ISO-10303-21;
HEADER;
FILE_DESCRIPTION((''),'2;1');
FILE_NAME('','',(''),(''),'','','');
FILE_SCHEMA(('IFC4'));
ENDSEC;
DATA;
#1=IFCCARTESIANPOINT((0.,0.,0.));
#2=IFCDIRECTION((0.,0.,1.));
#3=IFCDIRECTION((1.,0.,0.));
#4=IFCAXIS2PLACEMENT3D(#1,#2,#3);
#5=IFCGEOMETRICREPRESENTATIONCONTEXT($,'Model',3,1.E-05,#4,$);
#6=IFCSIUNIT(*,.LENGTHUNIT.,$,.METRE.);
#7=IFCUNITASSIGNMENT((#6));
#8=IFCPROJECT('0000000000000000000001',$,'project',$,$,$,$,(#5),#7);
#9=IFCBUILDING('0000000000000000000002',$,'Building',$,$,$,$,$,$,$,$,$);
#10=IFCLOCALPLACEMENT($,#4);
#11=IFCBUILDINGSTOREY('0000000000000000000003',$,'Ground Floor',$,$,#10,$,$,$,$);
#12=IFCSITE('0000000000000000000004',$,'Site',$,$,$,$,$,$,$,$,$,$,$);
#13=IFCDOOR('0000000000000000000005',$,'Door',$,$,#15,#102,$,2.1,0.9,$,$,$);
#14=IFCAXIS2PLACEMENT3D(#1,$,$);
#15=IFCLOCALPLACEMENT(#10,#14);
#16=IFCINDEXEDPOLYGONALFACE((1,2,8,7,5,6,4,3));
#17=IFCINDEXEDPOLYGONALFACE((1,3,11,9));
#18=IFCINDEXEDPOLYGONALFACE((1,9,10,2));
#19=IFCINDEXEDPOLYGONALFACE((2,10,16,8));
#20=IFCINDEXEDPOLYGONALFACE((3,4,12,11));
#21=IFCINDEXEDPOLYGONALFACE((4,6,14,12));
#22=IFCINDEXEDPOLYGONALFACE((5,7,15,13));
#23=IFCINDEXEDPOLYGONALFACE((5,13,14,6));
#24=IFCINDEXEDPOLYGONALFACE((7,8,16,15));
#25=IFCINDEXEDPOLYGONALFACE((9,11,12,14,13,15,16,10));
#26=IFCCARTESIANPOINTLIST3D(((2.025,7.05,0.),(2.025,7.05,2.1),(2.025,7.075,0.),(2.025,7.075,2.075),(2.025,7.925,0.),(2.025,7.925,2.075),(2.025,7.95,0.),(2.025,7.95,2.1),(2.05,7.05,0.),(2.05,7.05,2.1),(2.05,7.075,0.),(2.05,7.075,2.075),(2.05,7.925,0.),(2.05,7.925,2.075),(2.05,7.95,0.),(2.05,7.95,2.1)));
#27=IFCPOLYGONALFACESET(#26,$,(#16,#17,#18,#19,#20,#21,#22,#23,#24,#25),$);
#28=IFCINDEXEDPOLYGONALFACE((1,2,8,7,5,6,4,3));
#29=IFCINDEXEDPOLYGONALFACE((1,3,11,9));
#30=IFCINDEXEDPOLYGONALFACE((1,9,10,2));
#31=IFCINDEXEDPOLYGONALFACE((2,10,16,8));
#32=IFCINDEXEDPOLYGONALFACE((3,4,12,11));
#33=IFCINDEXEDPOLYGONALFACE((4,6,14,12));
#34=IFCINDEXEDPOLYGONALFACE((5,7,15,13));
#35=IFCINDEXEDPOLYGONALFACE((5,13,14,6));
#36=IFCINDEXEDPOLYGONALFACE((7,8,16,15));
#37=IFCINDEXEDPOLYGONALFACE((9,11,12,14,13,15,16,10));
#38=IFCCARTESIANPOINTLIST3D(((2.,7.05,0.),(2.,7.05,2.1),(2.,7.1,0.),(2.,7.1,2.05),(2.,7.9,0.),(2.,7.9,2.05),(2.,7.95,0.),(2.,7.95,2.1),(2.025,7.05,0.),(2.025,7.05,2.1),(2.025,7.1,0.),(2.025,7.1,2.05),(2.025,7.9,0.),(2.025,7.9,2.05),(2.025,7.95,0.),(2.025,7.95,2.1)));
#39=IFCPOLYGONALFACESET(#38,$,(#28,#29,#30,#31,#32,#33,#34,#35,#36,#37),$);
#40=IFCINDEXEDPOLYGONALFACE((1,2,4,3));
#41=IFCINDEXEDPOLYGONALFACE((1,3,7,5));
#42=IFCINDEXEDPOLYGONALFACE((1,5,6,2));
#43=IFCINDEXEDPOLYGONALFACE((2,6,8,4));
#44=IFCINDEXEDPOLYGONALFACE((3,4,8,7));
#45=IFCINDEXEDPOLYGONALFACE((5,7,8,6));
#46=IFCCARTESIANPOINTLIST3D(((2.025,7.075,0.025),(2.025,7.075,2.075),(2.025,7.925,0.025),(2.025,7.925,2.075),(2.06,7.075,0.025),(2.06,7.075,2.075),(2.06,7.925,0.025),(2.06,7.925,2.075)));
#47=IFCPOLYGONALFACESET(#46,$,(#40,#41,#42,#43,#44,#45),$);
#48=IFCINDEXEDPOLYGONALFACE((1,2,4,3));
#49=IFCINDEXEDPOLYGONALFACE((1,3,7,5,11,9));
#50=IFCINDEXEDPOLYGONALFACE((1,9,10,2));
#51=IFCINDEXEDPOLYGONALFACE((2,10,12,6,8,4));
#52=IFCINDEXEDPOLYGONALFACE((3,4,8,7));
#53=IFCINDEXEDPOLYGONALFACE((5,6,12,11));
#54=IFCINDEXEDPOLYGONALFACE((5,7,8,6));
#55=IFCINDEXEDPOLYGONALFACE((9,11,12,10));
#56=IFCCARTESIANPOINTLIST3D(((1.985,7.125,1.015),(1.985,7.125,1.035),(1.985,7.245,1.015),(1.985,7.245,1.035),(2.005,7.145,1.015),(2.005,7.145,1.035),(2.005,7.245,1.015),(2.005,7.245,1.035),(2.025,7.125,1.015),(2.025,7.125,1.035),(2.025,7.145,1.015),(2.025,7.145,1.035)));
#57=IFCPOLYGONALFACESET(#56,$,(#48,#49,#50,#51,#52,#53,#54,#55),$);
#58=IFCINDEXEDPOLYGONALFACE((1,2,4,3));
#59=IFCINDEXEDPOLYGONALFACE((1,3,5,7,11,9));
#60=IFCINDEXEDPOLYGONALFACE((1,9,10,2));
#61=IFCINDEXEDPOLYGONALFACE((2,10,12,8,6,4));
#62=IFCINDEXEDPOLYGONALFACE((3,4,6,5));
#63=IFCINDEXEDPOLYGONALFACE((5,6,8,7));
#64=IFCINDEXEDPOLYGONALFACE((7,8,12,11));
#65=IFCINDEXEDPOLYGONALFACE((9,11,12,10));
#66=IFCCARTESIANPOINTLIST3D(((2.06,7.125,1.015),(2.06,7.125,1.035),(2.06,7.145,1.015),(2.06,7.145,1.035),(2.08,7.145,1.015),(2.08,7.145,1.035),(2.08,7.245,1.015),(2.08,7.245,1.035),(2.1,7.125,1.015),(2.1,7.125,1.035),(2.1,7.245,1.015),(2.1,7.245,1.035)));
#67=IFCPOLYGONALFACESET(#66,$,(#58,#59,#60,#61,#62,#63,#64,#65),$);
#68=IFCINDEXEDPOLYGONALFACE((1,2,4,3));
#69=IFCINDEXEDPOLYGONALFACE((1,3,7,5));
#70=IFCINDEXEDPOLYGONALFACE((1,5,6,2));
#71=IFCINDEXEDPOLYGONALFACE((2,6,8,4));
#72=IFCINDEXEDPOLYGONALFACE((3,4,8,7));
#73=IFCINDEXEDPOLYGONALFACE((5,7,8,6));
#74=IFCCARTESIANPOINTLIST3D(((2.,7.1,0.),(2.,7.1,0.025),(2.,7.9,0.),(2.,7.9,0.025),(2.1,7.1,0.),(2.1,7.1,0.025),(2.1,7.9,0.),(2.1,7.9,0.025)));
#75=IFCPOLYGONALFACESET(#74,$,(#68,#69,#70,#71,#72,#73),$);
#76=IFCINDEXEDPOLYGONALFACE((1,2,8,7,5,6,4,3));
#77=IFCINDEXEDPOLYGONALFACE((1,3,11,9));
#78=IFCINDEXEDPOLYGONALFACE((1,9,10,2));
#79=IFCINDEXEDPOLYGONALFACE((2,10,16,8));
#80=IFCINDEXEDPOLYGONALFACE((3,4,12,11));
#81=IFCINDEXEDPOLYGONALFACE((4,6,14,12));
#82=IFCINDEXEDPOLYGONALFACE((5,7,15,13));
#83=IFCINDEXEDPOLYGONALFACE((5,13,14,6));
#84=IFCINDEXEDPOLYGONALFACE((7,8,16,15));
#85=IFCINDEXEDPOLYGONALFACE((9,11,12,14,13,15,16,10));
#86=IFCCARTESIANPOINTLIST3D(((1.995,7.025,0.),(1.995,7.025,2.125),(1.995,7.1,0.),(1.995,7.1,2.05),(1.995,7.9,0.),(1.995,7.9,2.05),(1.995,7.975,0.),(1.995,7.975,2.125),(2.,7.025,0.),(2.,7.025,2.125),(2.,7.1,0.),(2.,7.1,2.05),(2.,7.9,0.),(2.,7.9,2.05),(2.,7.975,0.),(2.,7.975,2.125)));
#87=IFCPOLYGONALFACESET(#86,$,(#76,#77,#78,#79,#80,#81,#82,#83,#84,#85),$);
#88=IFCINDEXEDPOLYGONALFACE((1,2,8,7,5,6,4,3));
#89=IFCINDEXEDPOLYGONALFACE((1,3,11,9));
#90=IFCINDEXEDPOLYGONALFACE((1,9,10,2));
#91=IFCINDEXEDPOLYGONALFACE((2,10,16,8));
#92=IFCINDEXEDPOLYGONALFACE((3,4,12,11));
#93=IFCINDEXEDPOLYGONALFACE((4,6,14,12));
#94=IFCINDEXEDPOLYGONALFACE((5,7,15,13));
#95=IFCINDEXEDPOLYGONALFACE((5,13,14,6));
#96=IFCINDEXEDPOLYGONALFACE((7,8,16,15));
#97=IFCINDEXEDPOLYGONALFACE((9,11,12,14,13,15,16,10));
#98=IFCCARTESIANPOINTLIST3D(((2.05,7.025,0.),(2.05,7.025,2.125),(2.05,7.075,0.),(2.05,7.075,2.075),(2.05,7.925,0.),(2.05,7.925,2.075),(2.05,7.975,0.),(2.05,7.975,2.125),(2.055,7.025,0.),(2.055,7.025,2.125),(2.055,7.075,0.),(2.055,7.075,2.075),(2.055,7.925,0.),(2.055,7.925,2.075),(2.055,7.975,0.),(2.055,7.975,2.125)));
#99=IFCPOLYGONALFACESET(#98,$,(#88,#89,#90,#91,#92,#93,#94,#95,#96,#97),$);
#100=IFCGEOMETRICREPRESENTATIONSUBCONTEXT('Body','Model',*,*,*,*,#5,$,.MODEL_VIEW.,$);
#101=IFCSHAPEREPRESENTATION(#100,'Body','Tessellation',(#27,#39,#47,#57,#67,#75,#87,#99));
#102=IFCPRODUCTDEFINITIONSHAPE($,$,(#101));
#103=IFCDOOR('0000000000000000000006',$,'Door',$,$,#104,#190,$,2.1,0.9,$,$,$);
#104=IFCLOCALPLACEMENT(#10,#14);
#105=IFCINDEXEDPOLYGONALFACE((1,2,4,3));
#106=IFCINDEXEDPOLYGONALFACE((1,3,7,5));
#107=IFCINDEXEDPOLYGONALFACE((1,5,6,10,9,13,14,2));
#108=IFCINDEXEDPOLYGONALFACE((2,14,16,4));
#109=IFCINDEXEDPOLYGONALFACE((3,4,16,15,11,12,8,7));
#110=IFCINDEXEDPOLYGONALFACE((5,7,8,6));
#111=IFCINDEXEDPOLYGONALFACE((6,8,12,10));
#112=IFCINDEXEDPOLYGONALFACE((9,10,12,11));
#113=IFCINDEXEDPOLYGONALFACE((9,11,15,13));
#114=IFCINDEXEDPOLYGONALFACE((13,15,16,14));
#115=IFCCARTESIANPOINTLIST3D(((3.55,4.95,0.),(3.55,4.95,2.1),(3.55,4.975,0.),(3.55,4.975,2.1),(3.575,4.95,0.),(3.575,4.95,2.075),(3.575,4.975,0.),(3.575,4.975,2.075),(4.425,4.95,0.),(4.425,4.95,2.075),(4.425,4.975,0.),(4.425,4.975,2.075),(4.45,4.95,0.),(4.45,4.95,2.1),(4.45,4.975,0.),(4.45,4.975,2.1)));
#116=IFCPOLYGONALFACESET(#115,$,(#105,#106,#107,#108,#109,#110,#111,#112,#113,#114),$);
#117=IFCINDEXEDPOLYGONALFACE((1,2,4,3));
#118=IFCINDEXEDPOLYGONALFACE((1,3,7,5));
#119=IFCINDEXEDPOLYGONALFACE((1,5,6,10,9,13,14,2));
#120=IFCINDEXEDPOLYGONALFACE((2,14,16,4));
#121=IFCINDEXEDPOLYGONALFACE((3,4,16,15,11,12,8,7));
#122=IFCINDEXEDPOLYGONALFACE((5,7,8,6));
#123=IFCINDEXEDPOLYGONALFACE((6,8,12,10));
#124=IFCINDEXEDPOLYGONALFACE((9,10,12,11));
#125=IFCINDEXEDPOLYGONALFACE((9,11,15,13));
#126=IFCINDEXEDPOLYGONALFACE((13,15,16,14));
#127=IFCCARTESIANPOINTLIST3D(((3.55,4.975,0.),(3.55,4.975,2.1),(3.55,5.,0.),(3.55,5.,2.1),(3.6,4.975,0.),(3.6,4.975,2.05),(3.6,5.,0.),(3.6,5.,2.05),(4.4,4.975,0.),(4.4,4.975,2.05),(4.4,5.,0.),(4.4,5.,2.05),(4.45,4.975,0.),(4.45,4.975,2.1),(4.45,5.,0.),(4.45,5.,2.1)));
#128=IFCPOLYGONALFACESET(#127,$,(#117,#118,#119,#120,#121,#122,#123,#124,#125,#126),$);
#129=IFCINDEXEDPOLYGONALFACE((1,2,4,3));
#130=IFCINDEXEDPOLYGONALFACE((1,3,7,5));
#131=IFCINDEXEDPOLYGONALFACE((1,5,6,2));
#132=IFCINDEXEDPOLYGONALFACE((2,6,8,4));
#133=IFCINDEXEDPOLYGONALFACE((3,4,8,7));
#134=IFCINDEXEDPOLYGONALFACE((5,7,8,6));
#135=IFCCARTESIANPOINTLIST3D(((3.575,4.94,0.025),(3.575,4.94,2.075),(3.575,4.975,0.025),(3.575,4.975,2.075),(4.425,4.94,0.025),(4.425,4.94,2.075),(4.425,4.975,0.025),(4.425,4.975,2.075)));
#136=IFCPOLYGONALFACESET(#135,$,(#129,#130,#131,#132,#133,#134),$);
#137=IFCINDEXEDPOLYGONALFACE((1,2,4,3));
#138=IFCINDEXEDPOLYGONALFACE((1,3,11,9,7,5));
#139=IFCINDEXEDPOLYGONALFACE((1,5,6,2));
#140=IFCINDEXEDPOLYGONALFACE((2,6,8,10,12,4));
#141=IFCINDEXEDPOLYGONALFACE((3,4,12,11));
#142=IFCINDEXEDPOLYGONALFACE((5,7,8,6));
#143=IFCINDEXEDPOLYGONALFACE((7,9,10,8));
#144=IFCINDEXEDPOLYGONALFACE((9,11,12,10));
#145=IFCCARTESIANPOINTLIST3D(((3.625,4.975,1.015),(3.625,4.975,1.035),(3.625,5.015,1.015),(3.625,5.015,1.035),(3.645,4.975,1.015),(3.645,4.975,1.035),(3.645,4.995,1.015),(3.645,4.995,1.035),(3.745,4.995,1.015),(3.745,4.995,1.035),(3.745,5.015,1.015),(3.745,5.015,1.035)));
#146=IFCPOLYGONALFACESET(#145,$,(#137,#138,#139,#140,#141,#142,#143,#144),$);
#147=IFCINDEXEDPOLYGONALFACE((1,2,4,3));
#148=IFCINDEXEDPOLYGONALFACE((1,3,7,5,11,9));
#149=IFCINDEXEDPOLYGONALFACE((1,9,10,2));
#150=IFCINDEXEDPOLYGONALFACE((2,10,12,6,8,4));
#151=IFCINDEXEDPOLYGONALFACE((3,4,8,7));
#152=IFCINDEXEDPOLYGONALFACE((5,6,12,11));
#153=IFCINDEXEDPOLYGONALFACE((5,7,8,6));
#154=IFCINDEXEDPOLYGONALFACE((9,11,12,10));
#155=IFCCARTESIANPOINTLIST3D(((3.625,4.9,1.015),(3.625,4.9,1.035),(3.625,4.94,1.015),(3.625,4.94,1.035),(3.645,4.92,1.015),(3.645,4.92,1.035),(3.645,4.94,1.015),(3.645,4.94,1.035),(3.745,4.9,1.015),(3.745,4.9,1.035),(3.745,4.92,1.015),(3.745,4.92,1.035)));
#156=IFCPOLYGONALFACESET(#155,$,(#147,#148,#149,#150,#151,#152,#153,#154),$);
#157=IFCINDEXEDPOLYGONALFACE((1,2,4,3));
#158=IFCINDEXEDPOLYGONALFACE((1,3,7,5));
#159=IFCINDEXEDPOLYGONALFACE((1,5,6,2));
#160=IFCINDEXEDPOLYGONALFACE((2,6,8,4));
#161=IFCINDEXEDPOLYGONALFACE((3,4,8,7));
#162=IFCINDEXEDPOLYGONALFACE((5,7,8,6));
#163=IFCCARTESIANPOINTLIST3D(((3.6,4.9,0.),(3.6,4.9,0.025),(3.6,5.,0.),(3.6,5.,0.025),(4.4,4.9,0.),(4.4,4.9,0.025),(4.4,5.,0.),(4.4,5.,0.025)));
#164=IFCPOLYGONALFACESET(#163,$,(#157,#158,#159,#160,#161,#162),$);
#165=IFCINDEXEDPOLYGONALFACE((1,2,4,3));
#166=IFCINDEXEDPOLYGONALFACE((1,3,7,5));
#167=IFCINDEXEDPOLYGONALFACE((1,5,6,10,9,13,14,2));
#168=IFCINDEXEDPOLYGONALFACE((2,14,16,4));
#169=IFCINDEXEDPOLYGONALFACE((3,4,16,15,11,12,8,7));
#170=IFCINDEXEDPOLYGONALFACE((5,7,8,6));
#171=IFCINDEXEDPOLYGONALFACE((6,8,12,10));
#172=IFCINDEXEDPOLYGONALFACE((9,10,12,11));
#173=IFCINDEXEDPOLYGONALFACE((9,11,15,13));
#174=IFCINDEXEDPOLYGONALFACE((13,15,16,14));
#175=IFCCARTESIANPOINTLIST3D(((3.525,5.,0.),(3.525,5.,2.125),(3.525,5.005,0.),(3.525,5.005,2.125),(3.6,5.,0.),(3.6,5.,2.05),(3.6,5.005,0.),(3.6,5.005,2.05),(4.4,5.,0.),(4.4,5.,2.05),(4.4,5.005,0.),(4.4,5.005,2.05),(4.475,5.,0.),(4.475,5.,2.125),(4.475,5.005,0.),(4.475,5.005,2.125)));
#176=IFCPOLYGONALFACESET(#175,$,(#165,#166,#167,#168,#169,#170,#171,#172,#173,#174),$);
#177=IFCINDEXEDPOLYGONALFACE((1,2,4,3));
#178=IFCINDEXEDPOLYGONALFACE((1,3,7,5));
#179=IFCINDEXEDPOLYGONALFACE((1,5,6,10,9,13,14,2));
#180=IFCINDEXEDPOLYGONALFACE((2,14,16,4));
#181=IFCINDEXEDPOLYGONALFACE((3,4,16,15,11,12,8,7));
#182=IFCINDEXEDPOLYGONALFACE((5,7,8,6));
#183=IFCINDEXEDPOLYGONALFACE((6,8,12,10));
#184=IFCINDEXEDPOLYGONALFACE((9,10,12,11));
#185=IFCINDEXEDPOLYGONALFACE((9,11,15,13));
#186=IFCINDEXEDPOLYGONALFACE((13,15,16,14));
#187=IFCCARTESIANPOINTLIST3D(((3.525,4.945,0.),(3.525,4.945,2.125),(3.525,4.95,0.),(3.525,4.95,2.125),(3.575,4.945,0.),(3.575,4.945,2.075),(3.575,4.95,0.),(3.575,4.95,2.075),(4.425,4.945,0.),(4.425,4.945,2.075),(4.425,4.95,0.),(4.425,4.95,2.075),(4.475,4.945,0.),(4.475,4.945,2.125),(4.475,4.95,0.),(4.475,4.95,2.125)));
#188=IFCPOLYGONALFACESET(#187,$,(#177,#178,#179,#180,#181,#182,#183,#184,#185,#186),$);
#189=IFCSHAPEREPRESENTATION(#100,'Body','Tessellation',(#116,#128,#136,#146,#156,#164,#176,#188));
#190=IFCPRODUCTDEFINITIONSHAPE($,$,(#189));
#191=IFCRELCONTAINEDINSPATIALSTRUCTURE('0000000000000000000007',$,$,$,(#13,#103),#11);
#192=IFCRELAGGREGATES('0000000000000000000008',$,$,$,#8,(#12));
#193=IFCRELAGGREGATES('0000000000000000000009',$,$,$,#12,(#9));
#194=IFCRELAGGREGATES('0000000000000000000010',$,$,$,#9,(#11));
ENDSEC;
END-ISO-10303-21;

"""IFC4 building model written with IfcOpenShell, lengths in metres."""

from ifc_helpers import new_model, si_unit, frame, origin_with_axes, place, context, subcontext, project, spatial, line, indexed_curve, outline, extrude, element, save


model = new_model("IFC4")

# Units and contexts
model_context = context("Model", 3, precision=1e-05, world=origin_with_axes())
body_context = subcontext(model_context, "Body", "Model", "MODEL_VIEW")
ifc_project = project(units=[si_unit("LENGTHUNIT", "METRE")], contexts=[model_context])

# Site, building, storey
site = spatial("IfcSite", under=ifc_project, Name="Site")
building = spatial("IfcBuilding", under=site, Name="Building")
storey_placement = place(None, origin_with_axes())
storey = spatial("IfcBuildingStorey", under=building, at=storey_placement, Name="Ground Floor")

# Doors
door_1_placement = place(storey_placement, frame((2.0, 7.95, 0.0), z_axis=(0.0, 0.0, 1.0), x_axis=(0.0, -1.0, 0.0)))
element("IfcDoor", 1, at=door_1_placement, inside=storey, Name="Door", OverallHeight=2.1, OverallWidth=0.9, context=body_context, shape_type="SweptSolid", body=[
    extrude(outline(indexed_curve([(0.0, 0.0), (0.0, 2.1), (0.9, 2.1), (0.9, 0.0), (0.875, 0.0), (0.875, 2.075), (0.025, 2.075), (0.025, 0.0)], segments=[line(1, 2, 3, 4, 5, 6, 7, 8, 1)])), frame((0.0, 0.025, 0.0), z_axis=(0.0, -1.0, 0.0), x_axis=(1.0, 0.0, 0.0)), (0.0, 0.0, -1.0), 0.025),
    extrude(outline(indexed_curve([(0.0, 0.0), (0.0, 2.1), (0.9, 2.1), (0.9, 0.0), (0.85, 0.0), (0.85, 2.05), (0.05, 2.05), (0.05, 0.0)], segments=[line(1, 2, 3, 4, 5, 6, 7, 8, 1)])), frame((0.0, 0.0, 0.0), z_axis=(0.0, -1.0, 0.0), x_axis=(1.0, 0.0, 0.0)), (0.0, 0.0, -1.0), 0.025),
    extrude(outline(indexed_curve([(0.0, 0.0), (0.85, 0.0), (0.85, 0.035), (0.0, 0.035)], segments=[line(1, 2, 3, 4, 1)])), frame((0.025, 0.025, 0.025), z_axis=(0.0, 0.0, 1.0), x_axis=(1.0, 0.0, 0.0)), (0.0, 0.0, 1.0), 2.05),
    extrude(outline(indexed_curve([(0.0, 0.0), (0.0, -0.04), (-0.12, -0.04), (-0.12, -0.02), (-0.02, -0.02), (-0.02, 0.0)], segments=[line(1, 2, 3, 4, 5, 6, 1)])), frame((0.825, 0.025, 1.015), z_axis=(0.0, 0.0, 1.0), x_axis=(1.0, 0.0, 0.0)), (0.0, 0.0, 1.0), 0.02),
    extrude(outline(indexed_curve([(0.0, 0.0), (0.0, 0.04), (-0.12, 0.04), (-0.12, 0.02), (-0.02, 0.02), (-0.02, 0.0)], segments=[line(1, 2, 3, 4, 5, 6, 1)])), frame((0.825, 0.06, 1.015), z_axis=(0.0, 0.0, 1.0), x_axis=(1.0, 0.0, 0.0)), (0.0, 0.0, 1.0), 0.02),
    extrude(outline(indexed_curve([(0.0, 0.0), (0.8, 0.0), (0.8, 0.1), (0.0, 0.1)], segments=[line(1, 2, 3, 4, 1)])), frame((0.05, 0.0, 0.0), z_axis=(0.0, 0.0, 1.0), x_axis=(1.0, 0.0, 0.0)), (0.0, 0.0, 1.0), 0.025),
    extrude(outline(indexed_curve([(0.0, 0.0), (0.0, 2.125), (0.95, 2.125), (0.95, 0.0), (0.875, 0.0), (0.875, 2.05), (0.075, 2.05), (0.075, 0.0)], segments=[line(1, 2, 3, 4, 5, 6, 7, 8, 1)])), frame((-0.025, -0.005, 0.0), z_axis=(0.0, -1.0, 0.0), x_axis=(1.0, 0.0, 0.0)), (0.0, 0.0, -1.0), 0.005),
    extrude(outline(indexed_curve([(0.0, 0.0), (0.0, 2.125), (0.95, 2.125), (0.95, 0.0), (0.9, 0.0), (0.9, 2.075), (0.05, 2.075), (0.05, 0.0)], segments=[line(1, 2, 3, 4, 5, 6, 7, 8, 1)])), frame((-0.025, 0.05, 0.0), z_axis=(0.0, -1.0, 0.0), x_axis=(1.0, 0.0, 0.0)), (0.0, 0.0, -1.0), 0.005),
])
door_2_placement = place(storey_placement, frame((4.45, 5.0, 0.0), z_axis=(0.0, 0.0, 1.0), x_axis=(-1.0, 0.0, 0.0)))
element("IfcDoor", 2, at=door_2_placement, inside=storey, Name="Door", OverallHeight=2.1, OverallWidth=0.9, context=body_context, shape_type="SweptSolid", body=[
    extrude(outline(indexed_curve([(0.0, 0.0), (0.0, 2.1), (0.9, 2.1), (0.9, 0.0), (0.875, 0.0), (0.875, 2.075), (0.025, 2.075), (0.025, 0.0)], segments=[line(1, 2, 3, 4, 5, 6, 7, 8, 1)])), frame((0.0, 0.025, 0.0), z_axis=(0.0, -1.0, 0.0), x_axis=(1.0, 0.0, 0.0)), (0.0, 0.0, -1.0), 0.025),
    extrude(outline(indexed_curve([(0.0, 0.0), (0.0, 2.1), (0.9, 2.1), (0.9, 0.0), (0.85, 0.0), (0.85, 2.05), (0.05, 2.05), (0.05, 0.0)], segments=[line(1, 2, 3, 4, 5, 6, 7, 8, 1)])), frame((0.0, 0.0, 0.0), z_axis=(0.0, -1.0, 0.0), x_axis=(1.0, 0.0, 0.0)), (0.0, 0.0, -1.0), 0.025),
    extrude(outline(indexed_curve([(0.0, 0.0), (0.85, 0.0), (0.85, 0.035), (0.0, 0.035)], segments=[line(1, 2, 3, 4, 1)])), frame((0.025, 0.025, 0.025), z_axis=(0.0, 0.0, 1.0), x_axis=(1.0, 0.0, 0.0)), (0.0, 0.0, 1.0), 2.05),
    extrude(outline(indexed_curve([(0.0, 0.0), (0.0, -0.04), (-0.12, -0.04), (-0.12, -0.02), (-0.02, -0.02), (-0.02, 0.0)], segments=[line(1, 2, 3, 4, 5, 6, 1)])), frame((0.825, 0.025, 1.015), z_axis=(0.0, 0.0, 1.0), x_axis=(1.0, 0.0, 0.0)), (0.0, 0.0, 1.0), 0.02),
    extrude(outline(indexed_curve([(0.0, 0.0), (0.0, 0.04), (-0.12, 0.04), (-0.12, 0.02), (-0.02, 0.02), (-0.02, 0.0)], segments=[line(1, 2, 3, 4, 5, 6, 1)])), frame((0.825, 0.06, 1.015), z_axis=(0.0, 0.0, 1.0), x_axis=(1.0, 0.0, 0.0)), (0.0, 0.0, 1.0), 0.02),
    extrude(outline(indexed_curve([(0.0, 0.0), (0.8, 0.0), (0.8, 0.1), (0.0, 0.1)], segments=[line(1, 2, 3, 4, 1)])), frame((0.05, 0.0, 0.0), z_axis=(0.0, 0.0, 1.0), x_axis=(1.0, 0.0, 0.0)), (0.0, 0.0, 1.0), 0.025),
    extrude(outline(indexed_curve([(0.0, 0.0), (0.0, 2.125), (0.95, 2.125), (0.95, 0.0), (0.875, 0.0), (0.875, 2.05), (0.075, 2.05), (0.075, 0.0)], segments=[line(1, 2, 3, 4, 5, 6, 7, 8, 1)])), frame((-0.025, -0.005, 0.0), z_axis=(0.0, -1.0, 0.0), x_axis=(1.0, 0.0, 0.0)), (0.0, 0.0, -1.0), 0.005),
    extrude(outline(indexed_curve([(0.0, 0.0), (0.0, 2.125), (0.95, 2.125), (0.95, 0.0), (0.9, 0.0), (0.9, 2.075), (0.05, 2.075), (0.05, 0.0)], segments=[line(1, 2, 3, 4, 5, 6, 7, 8, 1)])), frame((-0.025, 0.05, 0.0), z_axis=(0.0, -1.0, 0.0), x_axis=(1.0, 0.0, 0.0)), (0.0, 0.0, -1.0), 0.005),
])

save(model, "model.ifc")
